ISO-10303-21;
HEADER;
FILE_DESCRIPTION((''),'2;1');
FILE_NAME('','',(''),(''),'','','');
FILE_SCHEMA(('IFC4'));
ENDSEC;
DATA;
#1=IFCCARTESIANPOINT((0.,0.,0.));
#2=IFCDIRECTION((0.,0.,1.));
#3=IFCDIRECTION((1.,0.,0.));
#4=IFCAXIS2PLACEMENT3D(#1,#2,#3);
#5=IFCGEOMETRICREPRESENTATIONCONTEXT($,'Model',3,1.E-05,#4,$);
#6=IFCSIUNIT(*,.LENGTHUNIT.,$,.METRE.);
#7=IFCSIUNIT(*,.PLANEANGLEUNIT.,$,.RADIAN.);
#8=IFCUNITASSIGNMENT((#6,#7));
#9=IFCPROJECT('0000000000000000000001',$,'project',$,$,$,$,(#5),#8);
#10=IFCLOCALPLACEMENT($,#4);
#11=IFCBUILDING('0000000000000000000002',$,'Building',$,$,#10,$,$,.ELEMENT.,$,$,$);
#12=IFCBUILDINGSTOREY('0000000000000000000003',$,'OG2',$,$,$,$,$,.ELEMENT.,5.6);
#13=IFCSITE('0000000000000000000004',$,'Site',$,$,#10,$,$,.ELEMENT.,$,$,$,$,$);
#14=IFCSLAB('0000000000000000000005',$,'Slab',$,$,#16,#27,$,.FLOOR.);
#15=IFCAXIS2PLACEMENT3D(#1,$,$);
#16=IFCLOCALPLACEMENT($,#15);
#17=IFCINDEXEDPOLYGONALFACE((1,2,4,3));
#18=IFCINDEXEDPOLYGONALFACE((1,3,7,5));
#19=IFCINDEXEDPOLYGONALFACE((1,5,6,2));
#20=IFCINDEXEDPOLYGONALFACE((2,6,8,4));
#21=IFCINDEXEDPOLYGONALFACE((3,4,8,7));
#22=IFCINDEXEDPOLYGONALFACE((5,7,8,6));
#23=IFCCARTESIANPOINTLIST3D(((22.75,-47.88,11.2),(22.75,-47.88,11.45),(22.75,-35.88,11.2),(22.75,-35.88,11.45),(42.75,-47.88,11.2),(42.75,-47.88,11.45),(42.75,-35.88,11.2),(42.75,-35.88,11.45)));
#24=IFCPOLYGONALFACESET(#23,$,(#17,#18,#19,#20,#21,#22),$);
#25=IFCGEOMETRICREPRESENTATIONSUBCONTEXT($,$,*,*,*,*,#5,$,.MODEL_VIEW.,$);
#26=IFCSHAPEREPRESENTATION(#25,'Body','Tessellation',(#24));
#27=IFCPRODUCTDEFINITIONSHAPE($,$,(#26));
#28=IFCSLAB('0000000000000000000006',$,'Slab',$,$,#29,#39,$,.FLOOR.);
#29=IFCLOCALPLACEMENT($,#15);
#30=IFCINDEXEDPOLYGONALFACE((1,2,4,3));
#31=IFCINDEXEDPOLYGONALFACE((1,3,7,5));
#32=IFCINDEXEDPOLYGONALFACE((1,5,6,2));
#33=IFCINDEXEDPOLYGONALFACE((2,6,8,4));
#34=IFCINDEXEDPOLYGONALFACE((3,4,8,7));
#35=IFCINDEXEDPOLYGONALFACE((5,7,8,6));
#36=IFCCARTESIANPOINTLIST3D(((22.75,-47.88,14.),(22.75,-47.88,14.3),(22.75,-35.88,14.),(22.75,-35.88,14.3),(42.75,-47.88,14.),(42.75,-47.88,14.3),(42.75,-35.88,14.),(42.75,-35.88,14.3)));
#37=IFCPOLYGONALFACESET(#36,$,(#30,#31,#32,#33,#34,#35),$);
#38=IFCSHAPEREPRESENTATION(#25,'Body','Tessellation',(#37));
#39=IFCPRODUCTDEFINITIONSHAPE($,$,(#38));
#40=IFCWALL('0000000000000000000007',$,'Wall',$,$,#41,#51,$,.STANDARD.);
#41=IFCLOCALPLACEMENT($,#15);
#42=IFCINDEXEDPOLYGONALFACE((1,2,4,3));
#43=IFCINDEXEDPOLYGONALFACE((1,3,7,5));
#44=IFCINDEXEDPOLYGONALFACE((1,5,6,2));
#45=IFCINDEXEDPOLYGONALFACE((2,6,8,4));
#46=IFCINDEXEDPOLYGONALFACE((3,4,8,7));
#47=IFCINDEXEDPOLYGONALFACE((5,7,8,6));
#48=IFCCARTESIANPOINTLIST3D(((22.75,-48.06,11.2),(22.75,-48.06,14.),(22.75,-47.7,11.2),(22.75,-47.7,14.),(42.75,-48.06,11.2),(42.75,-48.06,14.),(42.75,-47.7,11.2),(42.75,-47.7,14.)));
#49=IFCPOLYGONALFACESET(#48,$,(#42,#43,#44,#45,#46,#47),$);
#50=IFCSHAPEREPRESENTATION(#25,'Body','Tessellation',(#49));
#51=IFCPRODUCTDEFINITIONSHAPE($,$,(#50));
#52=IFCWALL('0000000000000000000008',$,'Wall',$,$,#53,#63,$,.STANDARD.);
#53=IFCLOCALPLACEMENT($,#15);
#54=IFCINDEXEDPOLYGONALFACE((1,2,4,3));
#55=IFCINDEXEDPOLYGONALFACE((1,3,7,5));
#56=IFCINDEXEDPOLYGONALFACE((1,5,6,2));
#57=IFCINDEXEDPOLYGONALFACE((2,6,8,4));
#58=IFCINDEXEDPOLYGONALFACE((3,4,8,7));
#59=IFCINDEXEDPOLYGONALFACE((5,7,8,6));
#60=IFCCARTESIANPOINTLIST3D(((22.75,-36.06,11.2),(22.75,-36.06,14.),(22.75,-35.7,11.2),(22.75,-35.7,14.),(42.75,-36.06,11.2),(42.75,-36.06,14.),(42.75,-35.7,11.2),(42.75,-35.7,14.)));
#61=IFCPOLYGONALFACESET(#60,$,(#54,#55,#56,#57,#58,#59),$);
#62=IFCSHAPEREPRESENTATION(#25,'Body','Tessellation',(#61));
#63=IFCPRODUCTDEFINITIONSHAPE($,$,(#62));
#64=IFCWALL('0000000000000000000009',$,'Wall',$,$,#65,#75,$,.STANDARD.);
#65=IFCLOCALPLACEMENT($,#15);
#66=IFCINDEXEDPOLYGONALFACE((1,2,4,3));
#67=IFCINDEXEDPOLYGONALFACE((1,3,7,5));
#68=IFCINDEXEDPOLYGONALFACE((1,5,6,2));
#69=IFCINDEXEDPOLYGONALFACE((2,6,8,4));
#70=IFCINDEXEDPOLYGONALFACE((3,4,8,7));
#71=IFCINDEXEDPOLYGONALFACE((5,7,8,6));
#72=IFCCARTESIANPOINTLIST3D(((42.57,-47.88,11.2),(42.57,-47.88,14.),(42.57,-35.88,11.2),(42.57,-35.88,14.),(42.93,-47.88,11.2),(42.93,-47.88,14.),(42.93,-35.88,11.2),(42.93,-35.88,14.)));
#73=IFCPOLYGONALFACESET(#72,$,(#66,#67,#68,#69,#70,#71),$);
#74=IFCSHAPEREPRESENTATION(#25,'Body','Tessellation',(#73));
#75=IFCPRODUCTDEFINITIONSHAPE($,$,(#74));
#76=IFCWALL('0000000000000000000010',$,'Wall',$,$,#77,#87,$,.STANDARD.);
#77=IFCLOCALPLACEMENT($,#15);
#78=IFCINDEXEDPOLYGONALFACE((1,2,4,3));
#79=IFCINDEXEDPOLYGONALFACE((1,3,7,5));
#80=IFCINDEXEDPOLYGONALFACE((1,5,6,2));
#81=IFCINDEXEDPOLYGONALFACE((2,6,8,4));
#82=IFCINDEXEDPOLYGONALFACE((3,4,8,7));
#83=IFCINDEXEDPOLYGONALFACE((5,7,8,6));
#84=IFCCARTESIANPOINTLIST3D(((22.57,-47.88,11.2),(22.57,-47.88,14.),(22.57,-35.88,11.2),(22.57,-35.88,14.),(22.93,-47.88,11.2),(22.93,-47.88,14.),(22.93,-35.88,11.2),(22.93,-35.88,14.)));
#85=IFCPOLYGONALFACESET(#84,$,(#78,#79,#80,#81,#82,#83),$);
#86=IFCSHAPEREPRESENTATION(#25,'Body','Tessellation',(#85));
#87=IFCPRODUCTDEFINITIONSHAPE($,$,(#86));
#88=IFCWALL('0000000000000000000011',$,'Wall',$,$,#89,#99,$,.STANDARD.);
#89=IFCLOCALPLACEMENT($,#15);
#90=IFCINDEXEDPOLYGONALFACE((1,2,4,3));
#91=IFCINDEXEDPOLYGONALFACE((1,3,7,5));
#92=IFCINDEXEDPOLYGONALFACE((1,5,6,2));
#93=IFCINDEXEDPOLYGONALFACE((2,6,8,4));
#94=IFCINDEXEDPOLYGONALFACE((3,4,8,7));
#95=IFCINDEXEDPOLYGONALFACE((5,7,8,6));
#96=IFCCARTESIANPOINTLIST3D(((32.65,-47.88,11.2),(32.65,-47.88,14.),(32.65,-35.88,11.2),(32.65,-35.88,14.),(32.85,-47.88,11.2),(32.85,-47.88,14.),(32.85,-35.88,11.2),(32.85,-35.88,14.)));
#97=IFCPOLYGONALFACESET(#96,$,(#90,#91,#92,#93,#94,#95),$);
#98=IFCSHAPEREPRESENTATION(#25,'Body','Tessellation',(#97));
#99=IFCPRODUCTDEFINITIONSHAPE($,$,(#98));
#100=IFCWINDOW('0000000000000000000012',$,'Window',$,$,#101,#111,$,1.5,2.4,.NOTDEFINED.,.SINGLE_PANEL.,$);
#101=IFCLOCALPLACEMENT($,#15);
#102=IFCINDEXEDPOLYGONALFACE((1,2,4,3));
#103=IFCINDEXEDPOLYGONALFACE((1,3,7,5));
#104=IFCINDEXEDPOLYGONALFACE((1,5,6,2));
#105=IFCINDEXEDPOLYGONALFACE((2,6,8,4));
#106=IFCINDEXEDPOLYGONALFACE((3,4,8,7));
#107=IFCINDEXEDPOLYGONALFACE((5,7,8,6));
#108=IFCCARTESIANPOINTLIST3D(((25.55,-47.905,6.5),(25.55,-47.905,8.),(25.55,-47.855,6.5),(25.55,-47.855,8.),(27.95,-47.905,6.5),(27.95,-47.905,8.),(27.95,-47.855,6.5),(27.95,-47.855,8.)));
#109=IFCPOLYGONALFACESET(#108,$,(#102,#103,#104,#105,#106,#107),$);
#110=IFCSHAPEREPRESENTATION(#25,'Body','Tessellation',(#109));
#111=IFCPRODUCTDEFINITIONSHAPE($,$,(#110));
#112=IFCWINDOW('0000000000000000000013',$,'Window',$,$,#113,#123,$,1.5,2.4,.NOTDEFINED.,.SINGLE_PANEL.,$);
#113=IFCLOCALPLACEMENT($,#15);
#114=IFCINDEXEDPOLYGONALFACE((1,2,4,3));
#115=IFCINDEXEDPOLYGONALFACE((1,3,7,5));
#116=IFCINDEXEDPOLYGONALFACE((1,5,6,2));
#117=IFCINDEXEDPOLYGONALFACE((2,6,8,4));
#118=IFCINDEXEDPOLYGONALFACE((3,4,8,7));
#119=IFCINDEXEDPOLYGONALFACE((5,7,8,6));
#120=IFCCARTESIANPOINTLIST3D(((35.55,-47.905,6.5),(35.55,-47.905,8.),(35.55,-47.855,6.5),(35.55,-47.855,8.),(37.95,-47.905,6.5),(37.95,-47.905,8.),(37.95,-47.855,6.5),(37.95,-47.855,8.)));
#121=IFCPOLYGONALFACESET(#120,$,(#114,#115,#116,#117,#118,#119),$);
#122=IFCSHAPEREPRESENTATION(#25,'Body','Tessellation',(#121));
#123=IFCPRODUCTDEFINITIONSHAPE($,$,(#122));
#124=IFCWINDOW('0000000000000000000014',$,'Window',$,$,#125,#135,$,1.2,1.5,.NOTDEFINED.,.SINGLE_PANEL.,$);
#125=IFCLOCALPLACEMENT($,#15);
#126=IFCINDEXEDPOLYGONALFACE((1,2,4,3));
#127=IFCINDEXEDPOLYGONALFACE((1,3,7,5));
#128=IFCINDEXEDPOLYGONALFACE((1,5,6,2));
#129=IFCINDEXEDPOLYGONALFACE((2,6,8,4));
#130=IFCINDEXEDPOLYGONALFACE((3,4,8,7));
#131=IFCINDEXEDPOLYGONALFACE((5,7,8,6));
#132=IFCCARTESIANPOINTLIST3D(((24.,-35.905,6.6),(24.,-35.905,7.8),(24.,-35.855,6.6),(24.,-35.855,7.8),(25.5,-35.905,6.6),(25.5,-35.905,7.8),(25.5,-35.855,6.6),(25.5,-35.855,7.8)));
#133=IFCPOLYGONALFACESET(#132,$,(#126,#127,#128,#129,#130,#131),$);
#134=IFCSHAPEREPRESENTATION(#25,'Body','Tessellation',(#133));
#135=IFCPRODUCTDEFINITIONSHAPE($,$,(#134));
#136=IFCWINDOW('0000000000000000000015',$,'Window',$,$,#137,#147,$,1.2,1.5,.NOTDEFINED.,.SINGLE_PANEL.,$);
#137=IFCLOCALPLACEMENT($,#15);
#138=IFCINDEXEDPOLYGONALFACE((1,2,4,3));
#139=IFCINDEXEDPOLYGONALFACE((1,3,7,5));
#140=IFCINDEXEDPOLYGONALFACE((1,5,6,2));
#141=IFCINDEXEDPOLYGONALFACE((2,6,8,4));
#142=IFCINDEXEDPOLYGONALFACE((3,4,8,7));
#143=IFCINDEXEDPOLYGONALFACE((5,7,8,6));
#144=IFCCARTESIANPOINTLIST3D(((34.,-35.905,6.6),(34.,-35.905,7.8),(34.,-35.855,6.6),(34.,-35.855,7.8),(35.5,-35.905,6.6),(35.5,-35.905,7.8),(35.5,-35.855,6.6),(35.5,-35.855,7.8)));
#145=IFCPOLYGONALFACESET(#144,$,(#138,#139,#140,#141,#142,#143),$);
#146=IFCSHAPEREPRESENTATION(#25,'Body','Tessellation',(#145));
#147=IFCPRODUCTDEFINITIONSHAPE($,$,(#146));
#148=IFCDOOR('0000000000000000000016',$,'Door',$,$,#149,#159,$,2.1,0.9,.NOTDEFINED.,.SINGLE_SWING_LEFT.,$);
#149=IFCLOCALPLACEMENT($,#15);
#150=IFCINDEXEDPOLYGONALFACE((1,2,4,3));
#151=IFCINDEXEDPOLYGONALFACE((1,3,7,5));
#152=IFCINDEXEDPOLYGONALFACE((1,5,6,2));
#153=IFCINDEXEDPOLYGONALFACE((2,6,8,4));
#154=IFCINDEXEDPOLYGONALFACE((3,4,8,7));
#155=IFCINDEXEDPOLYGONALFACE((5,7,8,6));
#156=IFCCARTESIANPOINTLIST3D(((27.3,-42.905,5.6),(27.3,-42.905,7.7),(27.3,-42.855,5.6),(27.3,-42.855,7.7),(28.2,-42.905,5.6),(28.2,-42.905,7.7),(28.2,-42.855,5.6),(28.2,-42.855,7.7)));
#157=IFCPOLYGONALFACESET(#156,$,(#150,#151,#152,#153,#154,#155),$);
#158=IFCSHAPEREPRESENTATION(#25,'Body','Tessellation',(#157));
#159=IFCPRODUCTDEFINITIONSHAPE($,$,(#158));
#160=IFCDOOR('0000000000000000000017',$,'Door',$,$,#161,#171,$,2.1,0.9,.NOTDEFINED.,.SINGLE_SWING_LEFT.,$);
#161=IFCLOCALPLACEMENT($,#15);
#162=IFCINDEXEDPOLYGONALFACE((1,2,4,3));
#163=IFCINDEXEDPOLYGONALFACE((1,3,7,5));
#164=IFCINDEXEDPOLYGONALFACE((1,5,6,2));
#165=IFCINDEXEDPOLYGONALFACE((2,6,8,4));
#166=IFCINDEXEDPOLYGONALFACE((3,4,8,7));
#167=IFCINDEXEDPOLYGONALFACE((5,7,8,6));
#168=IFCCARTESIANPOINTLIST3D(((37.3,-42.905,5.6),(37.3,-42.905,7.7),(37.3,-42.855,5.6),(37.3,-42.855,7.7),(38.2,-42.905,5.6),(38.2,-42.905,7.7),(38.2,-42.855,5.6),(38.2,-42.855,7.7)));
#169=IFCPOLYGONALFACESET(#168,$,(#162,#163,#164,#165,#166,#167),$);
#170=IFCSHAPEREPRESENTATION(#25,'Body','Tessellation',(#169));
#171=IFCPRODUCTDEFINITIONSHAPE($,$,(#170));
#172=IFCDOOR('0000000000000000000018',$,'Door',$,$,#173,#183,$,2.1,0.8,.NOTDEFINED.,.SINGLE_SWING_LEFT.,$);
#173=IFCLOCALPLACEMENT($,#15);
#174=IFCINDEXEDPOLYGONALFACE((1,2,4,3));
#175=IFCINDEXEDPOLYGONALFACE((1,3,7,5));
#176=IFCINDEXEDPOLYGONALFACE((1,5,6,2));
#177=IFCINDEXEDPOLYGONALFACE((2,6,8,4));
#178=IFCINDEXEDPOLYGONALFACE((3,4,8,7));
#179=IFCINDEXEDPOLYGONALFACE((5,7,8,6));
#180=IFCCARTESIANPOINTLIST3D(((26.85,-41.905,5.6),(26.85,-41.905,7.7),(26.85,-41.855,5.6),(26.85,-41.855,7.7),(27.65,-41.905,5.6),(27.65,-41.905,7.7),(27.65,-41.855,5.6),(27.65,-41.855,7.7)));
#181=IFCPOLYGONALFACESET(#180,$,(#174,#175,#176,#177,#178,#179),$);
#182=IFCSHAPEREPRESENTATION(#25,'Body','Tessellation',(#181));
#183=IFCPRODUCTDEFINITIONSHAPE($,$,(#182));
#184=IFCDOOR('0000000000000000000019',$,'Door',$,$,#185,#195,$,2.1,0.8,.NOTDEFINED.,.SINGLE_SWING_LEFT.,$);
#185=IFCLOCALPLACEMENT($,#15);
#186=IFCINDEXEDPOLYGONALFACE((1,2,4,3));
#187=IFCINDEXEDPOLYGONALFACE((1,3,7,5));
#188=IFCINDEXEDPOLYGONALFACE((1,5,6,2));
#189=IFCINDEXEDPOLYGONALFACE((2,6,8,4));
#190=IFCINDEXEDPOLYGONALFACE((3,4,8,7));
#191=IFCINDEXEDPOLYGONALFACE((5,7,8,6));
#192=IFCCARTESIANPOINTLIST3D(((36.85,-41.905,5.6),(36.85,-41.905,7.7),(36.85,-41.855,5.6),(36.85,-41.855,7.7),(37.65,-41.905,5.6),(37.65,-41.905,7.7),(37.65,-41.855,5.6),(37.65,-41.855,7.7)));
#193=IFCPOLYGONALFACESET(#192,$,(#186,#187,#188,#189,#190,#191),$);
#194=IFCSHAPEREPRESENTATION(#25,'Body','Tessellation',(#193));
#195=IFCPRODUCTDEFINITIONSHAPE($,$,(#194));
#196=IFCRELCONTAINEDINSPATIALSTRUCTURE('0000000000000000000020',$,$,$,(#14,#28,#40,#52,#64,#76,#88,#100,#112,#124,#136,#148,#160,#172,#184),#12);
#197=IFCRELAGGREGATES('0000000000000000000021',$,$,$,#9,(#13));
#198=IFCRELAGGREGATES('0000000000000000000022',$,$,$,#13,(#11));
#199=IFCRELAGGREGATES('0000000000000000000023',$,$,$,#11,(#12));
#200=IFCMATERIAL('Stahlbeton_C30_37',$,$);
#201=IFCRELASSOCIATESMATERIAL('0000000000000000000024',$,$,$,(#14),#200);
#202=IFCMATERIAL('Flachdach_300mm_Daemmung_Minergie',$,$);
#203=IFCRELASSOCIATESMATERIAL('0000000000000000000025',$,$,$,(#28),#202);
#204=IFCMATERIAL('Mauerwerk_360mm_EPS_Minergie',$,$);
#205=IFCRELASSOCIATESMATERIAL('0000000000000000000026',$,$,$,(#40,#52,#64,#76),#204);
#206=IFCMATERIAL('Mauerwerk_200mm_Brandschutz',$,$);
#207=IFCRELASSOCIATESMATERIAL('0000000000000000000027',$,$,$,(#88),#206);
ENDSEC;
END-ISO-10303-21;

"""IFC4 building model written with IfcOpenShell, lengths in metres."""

from ifc_helpers import new_model, si_unit, frame, frame_2d, origin, origin_with_axes, origin_2d, place, context, subcontext, project, spatial, rectangle, extrude, material, element, save


model = new_model("IFC4")

# Units and contexts
model_context = context("Model", 3, precision=1e-05, world=origin_with_axes())
sub_context = subcontext(model_context, None, None, "MODEL_VIEW")
ifc_project = project(units=[si_unit("LENGTHUNIT", "METRE"), si_unit("PLANEANGLEUNIT", "RADIAN")], contexts=[model_context])

# Site, building, storey
placement_1 = place(None, origin_with_axes())
site = spatial("IfcSite", under=ifc_project, at=placement_1, Name="Site", CompositionType="ELEMENT")
building = spatial("IfcBuilding", under=site, at=placement_1, Name="Building", CompositionType="ELEMENT")
storey = spatial("IfcBuildingStorey", under=building, Name="OG2", CompositionType="ELEMENT", Elevation=5.6)

# Shared definitions
ifc_material_1 = material(Name="Stahlbeton_C30_37")
placement_2 = place(placement_1, frame((0.0, 0.0, 5.6)))

# Slabs
slab_1_placement = place(placement_2, frame((22.75, -47.88, 5.6)))
element("IfcSlab", 1, at=slab_1_placement, inside=storey, material=ifc_material_1, Name="Slab", PredefinedType="FLOOR", context=sub_context, shape_type="SweptSolid", body=[
    extrude(rectangle(XDim=20.0, YDim=12.0, at=frame_2d((10.0, 6.0))), origin(), (0.0, 0.0, 1.0), 0.25),
])
ifc_material_2 = material(Name="Flachdach_300mm_Daemmung_Minergie")
slab_2_placement = place(placement_2, frame((22.75, -47.88, 8.4)))
element("IfcSlab", 2, at=slab_2_placement, inside=storey, material=ifc_material_2, Name="Slab", PredefinedType="FLOOR", context=sub_context, shape_type="SweptSolid", body=[
    extrude(rectangle(XDim=20.0, YDim=12.0, at=frame_2d((10.0, 6.0))), origin(), (0.0, 0.0, 1.0), 0.3),
])

# Walls
ifc_material_3 = material(Name="Mauerwerk_360mm_EPS_Minergie")
for number, where, x_axis, name in (
    (3, (22.75, -47.88, 5.6), (1.0, 0.0, 0.0), "Wall"),
    (4, (22.75, -35.88, 5.6), (1.0, 0.0, 0.0), "Wall"),
):
    element("IfcWall", number, at=place(placement_2, frame(where, x_axis=x_axis)), inside=storey, material=ifc_material_3, Name=name, PredefinedType="STANDARD", context=sub_context, shape_type="SweptSolid", body=[
        extrude(rectangle(XDim=20.0, YDim=0.36, at=frame_2d((10.0, 0.0))), origin(), (0.0, 0.0, 1.0), 2.8),
    ])
for number, where, x_axis, name in (
    (5, (42.75, -47.88, 5.6), (0.0, 1.0, 0.0), "Wall"),
    (6, (22.75, -47.88, 5.6), (0.0, 1.0, 0.0), "Wall"),
):
    element("IfcWall", number, at=place(placement_2, frame(where, x_axis=x_axis)), inside=storey, material=ifc_material_3, Name=name, PredefinedType="STANDARD", context=sub_context, shape_type="SweptSolid", body=[
        extrude(rectangle(XDim=12.0, YDim=0.36, at=frame_2d((6.0, 0.0))), origin(), (0.0, 0.0, 1.0), 2.8),
    ])
ifc_material_4 = material(Name="Mauerwerk_200mm_Brandschutz")
wall_placement = place(placement_2, frame((32.75, -47.88, 5.6), x_axis=(0.0, 1.0, 0.0)))
element("IfcWall", 7, at=wall_placement, inside=storey, material=ifc_material_4, Name="Wall", PredefinedType="STANDARD", context=sub_context, shape_type="SweptSolid", body=[
    extrude(rectangle(XDim=12.0, YDim=0.2, at=frame_2d((6.0, 0.0))), origin(), (0.0, 0.0, 1.0), 2.8),
])

# Windows
for number, where, name in (
    (8, (26.75, -47.88, 6.5), "Window"),
    (9, (36.75, -47.88, 6.5), "Window"),
):
    element("IfcWindow", number, at=place(placement_1, frame(where)), inside=storey, Name=name, OverallHeight=1.5, OverallWidth=2.4, PartitioningType="SINGLE_PANEL", PredefinedType="NOTDEFINED", context=sub_context, shape_type="SweptSolid", body=[
        extrude(rectangle(XDim=2.4, YDim=0.05, at=origin_2d()), origin(), (0.0, 0.0, 1.0), 1.5),
    ])
for number, where, name in (
    (10, (24.75, -35.88, 6.6), "Window"),
    (11, (34.75, -35.88, 6.6), "Window"),
):
    element("IfcWindow", number, at=place(placement_1, frame(where)), inside=storey, Name=name, OverallHeight=1.2, OverallWidth=1.5, PartitioningType="SINGLE_PANEL", PredefinedType="NOTDEFINED", context=sub_context, shape_type="SweptSolid", body=[
        extrude(rectangle(XDim=1.5, YDim=0.05, at=origin_2d()), origin(), (0.0, 0.0, 1.0), 1.2),
    ])

# Doors
for number, where, name in (
    (12, (27.75, -42.88, 5.6), "Door"),
    (13, (37.75, -42.88, 5.6), "Door"),
):
    element("IfcDoor", number, at=place(placement_1, frame(where)), inside=storey, Name=name, OperationType="SINGLE_SWING_LEFT", OverallHeight=2.1, OverallWidth=0.9, PredefinedType="NOTDEFINED", context=sub_context, shape_type="SweptSolid", body=[
        extrude(rectangle(XDim=0.9, YDim=0.05, at=origin_2d()), origin(), (0.0, 0.0, 1.0), 2.1),
    ])
for number, where, name in (
    (14, (27.25, -41.88, 5.6), "Door"),
    (15, (37.25, -41.88, 5.6), "Door"),
):
    element("IfcDoor", number, at=place(placement_1, frame(where)), inside=storey, Name=name, OperationType="SINGLE_SWING_LEFT", OverallHeight=2.1, OverallWidth=0.8, PredefinedType="NOTDEFINED", context=sub_context, shape_type="SweptSolid", body=[
        extrude(rectangle(XDim=0.8, YDim=0.05, at=origin_2d()), origin(), (0.0, 0.0, 1.0), 2.1),
    ])

save(model, "model.ifc")
